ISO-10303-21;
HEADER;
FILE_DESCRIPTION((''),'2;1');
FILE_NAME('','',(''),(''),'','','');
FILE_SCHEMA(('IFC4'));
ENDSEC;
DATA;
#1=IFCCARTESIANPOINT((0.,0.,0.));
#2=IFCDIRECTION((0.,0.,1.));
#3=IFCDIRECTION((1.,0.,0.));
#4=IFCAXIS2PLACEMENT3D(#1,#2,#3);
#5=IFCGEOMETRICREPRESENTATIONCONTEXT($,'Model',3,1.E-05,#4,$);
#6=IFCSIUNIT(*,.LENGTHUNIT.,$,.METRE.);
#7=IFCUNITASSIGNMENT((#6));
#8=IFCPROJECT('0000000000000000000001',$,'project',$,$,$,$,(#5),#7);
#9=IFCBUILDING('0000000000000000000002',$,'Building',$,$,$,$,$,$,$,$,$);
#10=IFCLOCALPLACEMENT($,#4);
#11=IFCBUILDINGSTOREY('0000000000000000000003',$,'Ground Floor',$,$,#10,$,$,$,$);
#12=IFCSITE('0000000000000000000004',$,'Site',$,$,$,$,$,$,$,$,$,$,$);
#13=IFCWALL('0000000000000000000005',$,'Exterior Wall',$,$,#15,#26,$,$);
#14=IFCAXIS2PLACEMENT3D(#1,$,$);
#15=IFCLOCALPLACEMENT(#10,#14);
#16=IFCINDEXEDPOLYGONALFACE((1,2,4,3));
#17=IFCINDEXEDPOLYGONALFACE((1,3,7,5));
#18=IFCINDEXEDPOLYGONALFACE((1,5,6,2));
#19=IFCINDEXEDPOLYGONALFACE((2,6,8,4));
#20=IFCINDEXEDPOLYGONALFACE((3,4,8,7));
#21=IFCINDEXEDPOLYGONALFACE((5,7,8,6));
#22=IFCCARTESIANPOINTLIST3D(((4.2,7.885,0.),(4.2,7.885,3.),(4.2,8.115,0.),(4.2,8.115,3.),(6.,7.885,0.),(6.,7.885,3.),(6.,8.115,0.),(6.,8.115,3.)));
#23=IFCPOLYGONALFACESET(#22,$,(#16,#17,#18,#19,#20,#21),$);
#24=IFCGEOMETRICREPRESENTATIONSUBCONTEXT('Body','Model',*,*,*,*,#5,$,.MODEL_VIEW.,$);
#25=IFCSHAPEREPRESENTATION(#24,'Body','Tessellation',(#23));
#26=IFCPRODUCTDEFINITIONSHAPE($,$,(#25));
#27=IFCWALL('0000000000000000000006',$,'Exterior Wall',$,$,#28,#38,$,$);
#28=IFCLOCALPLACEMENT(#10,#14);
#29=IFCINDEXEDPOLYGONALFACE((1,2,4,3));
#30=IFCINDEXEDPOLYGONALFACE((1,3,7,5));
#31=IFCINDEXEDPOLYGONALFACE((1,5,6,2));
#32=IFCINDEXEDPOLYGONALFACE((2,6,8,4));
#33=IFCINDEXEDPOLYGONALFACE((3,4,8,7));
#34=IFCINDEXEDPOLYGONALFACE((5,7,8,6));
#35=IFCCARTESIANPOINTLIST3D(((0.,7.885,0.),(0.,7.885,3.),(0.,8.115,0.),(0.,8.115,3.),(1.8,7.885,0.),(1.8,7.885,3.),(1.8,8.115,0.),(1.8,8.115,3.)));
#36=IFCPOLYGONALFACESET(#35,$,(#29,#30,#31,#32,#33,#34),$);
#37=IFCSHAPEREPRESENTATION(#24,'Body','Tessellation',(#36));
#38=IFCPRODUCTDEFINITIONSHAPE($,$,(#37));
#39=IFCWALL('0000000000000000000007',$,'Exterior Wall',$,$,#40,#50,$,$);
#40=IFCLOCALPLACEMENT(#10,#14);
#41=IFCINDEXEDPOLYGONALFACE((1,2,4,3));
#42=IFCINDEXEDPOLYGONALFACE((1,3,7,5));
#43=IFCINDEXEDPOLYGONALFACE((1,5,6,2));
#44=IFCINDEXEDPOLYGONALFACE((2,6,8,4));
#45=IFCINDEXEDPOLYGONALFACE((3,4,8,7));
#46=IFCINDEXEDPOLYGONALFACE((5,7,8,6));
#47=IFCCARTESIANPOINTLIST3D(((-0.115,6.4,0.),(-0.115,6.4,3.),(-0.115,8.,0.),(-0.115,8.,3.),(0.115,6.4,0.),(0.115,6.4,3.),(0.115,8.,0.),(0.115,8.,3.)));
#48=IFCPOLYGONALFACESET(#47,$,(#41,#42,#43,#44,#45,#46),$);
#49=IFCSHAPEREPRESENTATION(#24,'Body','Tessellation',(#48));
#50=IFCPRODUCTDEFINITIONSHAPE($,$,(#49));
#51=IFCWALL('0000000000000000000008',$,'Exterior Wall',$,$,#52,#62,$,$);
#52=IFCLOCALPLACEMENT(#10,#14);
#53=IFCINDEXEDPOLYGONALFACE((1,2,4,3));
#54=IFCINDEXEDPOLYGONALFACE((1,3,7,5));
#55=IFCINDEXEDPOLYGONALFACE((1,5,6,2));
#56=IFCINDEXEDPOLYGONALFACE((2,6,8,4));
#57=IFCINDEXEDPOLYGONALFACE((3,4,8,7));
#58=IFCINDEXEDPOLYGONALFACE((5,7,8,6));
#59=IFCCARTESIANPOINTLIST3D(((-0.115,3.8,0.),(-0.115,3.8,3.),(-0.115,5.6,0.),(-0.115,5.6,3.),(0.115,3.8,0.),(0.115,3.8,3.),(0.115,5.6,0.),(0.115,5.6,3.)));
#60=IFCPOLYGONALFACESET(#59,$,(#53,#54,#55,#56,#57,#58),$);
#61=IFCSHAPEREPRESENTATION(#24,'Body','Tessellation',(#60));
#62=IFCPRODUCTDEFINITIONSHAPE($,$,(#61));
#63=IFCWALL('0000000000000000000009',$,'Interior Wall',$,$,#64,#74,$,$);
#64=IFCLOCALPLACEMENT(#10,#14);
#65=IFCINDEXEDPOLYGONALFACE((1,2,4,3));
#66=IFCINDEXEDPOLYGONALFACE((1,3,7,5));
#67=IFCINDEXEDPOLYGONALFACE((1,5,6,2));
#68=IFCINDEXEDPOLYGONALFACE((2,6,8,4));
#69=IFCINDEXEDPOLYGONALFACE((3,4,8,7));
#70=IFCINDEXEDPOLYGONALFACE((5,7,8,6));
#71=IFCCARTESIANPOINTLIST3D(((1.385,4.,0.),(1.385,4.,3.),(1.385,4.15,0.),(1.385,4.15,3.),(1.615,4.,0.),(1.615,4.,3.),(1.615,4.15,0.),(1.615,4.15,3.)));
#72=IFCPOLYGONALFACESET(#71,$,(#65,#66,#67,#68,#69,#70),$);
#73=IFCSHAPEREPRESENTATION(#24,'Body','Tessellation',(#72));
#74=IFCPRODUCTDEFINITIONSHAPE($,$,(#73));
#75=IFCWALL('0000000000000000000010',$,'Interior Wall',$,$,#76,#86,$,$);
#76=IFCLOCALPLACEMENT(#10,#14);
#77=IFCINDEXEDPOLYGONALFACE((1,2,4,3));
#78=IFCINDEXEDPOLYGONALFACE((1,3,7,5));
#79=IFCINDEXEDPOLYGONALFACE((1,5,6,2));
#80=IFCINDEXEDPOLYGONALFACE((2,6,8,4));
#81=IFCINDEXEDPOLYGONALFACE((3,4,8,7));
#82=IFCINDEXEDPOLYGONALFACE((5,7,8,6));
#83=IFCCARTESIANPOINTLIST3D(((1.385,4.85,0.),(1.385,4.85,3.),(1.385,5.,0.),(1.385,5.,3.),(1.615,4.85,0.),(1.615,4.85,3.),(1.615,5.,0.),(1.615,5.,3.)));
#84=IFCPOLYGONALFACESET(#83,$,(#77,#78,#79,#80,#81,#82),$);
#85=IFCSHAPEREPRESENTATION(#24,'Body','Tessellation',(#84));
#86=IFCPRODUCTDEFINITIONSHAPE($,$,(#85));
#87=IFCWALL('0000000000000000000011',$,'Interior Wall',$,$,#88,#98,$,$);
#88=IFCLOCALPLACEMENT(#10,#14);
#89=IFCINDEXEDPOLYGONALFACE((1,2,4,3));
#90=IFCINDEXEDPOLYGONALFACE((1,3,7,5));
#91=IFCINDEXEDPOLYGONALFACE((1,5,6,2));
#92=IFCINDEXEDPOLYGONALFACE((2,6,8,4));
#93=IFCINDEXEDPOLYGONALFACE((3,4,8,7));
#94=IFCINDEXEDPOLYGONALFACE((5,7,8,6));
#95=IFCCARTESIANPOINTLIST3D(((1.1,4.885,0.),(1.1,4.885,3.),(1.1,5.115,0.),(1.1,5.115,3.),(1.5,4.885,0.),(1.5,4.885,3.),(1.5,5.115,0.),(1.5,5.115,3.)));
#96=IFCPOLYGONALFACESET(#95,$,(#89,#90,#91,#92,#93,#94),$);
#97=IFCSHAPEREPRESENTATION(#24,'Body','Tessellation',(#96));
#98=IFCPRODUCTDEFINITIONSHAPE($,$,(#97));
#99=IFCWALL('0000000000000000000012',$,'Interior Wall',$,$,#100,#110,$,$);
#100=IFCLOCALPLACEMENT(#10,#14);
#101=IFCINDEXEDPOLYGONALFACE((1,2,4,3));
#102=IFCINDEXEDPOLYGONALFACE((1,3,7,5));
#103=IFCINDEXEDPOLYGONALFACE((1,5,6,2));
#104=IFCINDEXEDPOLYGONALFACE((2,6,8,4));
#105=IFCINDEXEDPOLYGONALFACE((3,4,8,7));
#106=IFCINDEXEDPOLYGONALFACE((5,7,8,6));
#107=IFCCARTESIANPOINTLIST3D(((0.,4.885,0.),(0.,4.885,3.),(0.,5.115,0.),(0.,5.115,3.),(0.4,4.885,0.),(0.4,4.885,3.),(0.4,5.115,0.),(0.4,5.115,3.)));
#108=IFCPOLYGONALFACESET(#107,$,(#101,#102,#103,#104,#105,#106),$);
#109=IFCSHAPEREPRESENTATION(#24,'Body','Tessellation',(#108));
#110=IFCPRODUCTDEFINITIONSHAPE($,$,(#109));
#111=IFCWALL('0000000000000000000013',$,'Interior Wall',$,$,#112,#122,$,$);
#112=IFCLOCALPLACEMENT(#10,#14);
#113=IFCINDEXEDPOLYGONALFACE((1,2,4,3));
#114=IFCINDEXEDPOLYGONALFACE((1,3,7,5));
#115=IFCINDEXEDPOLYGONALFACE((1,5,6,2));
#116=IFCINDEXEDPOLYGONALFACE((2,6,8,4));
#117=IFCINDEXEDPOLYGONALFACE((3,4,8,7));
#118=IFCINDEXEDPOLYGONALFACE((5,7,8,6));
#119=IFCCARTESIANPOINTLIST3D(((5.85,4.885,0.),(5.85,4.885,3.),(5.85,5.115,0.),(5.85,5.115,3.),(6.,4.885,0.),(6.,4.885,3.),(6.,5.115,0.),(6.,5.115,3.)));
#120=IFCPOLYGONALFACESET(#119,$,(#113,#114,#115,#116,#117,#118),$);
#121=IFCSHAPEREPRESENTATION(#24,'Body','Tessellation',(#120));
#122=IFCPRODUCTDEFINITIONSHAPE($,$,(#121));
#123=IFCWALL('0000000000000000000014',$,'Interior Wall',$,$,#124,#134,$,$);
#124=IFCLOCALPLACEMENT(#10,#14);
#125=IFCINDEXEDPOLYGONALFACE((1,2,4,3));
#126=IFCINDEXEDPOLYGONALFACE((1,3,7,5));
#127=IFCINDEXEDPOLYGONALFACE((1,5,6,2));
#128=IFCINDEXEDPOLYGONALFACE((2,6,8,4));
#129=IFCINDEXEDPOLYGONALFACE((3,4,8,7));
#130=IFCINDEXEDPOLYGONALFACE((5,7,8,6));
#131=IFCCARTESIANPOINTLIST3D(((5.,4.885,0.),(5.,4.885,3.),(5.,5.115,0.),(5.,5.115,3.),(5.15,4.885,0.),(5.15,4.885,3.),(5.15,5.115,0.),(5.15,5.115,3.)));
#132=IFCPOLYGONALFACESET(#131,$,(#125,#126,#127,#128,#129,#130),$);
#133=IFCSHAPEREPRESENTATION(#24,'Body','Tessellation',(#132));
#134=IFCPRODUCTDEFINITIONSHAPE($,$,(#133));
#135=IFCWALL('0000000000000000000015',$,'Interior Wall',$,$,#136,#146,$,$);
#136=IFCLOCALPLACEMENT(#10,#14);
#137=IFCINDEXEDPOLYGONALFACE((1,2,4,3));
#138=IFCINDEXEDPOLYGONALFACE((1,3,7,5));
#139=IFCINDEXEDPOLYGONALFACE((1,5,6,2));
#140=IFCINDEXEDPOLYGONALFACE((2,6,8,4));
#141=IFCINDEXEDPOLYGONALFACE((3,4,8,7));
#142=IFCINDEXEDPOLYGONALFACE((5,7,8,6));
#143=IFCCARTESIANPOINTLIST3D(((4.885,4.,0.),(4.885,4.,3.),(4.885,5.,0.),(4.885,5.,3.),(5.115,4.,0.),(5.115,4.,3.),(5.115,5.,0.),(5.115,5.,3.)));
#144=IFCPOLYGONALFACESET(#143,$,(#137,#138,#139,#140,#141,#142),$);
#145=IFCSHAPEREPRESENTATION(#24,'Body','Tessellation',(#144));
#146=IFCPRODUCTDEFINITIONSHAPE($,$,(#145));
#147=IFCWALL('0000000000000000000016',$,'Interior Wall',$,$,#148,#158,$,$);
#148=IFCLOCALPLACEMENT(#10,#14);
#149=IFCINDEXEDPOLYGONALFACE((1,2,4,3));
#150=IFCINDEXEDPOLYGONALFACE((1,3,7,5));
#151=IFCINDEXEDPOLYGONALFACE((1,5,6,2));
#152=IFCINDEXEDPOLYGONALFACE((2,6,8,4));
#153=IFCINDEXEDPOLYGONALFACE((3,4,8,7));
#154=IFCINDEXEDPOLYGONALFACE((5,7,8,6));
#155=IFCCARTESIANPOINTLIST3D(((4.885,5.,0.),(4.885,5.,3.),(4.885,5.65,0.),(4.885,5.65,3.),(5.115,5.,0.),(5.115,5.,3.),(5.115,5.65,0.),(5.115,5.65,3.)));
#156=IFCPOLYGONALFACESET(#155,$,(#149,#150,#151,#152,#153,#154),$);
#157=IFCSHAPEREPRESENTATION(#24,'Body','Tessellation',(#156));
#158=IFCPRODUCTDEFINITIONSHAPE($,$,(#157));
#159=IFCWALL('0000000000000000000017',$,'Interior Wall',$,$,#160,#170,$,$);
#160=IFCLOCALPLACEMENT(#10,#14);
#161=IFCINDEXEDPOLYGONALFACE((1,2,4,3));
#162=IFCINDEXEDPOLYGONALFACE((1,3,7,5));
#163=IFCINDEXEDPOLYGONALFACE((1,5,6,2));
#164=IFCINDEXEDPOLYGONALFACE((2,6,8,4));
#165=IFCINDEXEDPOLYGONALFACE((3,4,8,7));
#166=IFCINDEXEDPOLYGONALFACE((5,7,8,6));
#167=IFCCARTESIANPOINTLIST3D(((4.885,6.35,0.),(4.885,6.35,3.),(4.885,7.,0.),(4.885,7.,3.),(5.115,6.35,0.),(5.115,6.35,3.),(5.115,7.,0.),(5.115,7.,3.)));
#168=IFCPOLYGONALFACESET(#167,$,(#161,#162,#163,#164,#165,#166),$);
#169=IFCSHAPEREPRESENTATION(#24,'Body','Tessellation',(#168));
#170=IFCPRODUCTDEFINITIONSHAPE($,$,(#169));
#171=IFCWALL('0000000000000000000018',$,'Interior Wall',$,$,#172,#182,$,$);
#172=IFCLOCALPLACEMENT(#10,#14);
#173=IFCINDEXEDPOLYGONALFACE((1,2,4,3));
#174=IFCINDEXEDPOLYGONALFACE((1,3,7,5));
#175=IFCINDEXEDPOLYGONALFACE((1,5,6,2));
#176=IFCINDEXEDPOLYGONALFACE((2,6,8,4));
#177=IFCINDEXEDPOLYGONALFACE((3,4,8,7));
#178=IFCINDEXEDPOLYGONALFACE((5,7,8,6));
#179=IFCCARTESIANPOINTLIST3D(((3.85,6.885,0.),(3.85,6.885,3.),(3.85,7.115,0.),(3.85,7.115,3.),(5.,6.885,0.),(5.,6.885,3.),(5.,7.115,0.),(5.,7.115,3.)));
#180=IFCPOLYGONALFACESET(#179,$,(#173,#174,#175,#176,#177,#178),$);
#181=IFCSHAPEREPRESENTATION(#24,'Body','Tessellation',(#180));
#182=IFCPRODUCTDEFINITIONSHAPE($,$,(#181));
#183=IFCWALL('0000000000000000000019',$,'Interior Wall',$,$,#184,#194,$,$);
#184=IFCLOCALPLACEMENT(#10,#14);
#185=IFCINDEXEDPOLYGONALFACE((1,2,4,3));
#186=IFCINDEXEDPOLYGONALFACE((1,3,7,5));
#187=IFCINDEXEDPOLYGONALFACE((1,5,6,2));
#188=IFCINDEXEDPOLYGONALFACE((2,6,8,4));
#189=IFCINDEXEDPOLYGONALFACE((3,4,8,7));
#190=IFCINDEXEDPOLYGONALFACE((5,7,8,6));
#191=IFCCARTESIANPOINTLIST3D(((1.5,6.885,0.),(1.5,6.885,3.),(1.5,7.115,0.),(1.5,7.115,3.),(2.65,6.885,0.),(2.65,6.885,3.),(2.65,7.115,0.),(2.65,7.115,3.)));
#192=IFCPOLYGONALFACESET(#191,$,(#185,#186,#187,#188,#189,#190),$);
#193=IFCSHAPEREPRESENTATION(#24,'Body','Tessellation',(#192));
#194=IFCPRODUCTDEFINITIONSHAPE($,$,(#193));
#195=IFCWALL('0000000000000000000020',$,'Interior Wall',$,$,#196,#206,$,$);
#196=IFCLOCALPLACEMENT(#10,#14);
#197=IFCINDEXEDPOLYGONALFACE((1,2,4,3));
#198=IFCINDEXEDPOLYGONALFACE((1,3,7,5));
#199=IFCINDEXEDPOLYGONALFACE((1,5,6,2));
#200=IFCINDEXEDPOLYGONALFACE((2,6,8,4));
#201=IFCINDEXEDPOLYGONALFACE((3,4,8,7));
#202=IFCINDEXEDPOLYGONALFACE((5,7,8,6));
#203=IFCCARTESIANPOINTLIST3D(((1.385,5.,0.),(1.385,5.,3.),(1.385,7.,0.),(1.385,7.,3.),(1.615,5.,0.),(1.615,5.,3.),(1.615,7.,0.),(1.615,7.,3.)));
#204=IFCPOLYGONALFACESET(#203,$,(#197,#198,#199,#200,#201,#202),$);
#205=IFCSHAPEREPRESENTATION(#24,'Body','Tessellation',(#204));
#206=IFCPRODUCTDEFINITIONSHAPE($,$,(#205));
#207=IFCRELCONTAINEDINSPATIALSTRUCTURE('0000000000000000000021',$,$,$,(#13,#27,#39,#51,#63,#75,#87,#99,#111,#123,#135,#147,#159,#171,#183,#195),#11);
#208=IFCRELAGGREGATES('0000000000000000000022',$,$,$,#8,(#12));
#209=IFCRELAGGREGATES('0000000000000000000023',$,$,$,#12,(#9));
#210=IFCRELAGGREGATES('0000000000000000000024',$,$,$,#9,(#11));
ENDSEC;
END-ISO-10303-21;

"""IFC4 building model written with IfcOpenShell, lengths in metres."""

from ifc_helpers import new_model, si_unit, frame, origin_with_axes, place, context, subcontext, project, spatial, indexed_curve, outline, extrude, element, save


model = new_model("IFC4")

# Units and contexts
model_context = context("Model", 3, precision=1e-05, world=origin_with_axes())
body_context = subcontext(model_context, "Body", "Model", "MODEL_VIEW")
ifc_project = project(units=[si_unit("LENGTHUNIT", "METRE")], contexts=[model_context])

# Site, building, storey
site = spatial("IfcSite", under=ifc_project, Name="Site")
building = spatial("IfcBuilding", under=site, Name="Building")
storey_placement = place(None, origin_with_axes())
storey = spatial("IfcBuildingStorey", under=building, at=storey_placement, Name="Ground Floor")

# Walls
for number, where, z_axis, x_axis, name in (
    (1, (6.0, 8.0, 0.0), (0.0, 0.0, 1.0), (-1.0, 0.0, 0.0), "Exterior Wall"),
    (2, (1.8, 8.0, 0.0), (0.0, 0.0, 1.0), (-1.0, 0.0, 0.0), "Exterior Wall"),
):
    element("IfcWall", number, at=place(storey_placement, frame(where, z_axis=z_axis, x_axis=x_axis)), inside=storey, Name=name, context=body_context, shape_type="SweptSolid", body=[
        extrude(outline(indexed_curve([(0.0, 0.0), (0.0, 0.23), (1.8, 0.23), (1.8, 0.0), (0.0, 0.0)], self_intersect=False)), frame((0.0, -0.115, 0.0), z_axis=(0.0, 0.0, 1.0), x_axis=(1.0, 0.0, 0.0)), (0.0, 0.0, 1.0), 3.0),
    ])
wall_1_placement = place(storey_placement, frame((0.0, 8.0, 0.0), z_axis=(0.0, 0.0, 1.0), x_axis=(0.0, -1.0, 0.0)))
element("IfcWall", 3, at=wall_1_placement, inside=storey, Name="Exterior Wall", context=body_context, shape_type="SweptSolid", body=[
    extrude(outline(indexed_curve([(0.0, 0.0), (0.0, 0.23), (1.6, 0.23), (1.6, 0.0), (0.0, 0.0)], self_intersect=False)), frame((0.0, -0.115, 0.0), z_axis=(0.0, 0.0, 1.0), x_axis=(1.0, 0.0, 0.0)), (0.0, 0.0, 1.0), 3.0),
])
wall_2_placement = place(storey_placement, frame((0.0, 5.6, 0.0), z_axis=(0.0, 0.0, 1.0), x_axis=(0.0, -1.0, 0.0)))
element("IfcWall", 4, at=wall_2_placement, inside=storey, Name="Exterior Wall", context=body_context, shape_type="SweptSolid", body=[
    extrude(outline(indexed_curve([(0.0, 0.0), (0.0, 0.23), (1.8, 0.23), (1.8, 0.0), (0.0, 0.0)], self_intersect=False)), frame((0.0, -0.115, 0.0), z_axis=(0.0, 0.0, 1.0), x_axis=(1.0, 0.0, 0.0)), (0.0, 0.0, 1.0), 3.0),
])
for number, where, z_axis, x_axis, name in (
    (5, (1.5, 4.0, 0.0), (0.0, 0.0, 1.0), (0.0, 1.0, 0.0), "Interior Wall"),
    (6, (1.5, 4.85, 0.0), (0.0, 0.0, 1.0), (0.0, 1.0, 0.0), "Interior Wall"),
):
    element("IfcWall", number, at=place(storey_placement, frame(where, z_axis=z_axis, x_axis=x_axis)), inside=storey, Name=name, context=body_context, shape_type="SweptSolid", body=[
        extrude(outline(indexed_curve([(0.0, 0.0), (0.0, 0.23), (0.15, 0.23), (0.15, 0.0), (0.0, 0.0)], self_intersect=False)), frame((0.0, -0.115, 0.0), z_axis=(0.0, 0.0, 1.0), x_axis=(1.0, 0.0, 0.0)), (0.0, 0.0, 1.0), 3.0),
    ])
for number, where, z_axis, x_axis, name in (
    (7, (1.5, 5.0, 0.0), (0.0, 0.0, 1.0), (-1.0, 0.0, 0.0), "Interior Wall"),
    (8, (0.4, 5.0, 0.0), (0.0, 0.0, 1.0), (-1.0, 0.0, 0.0), "Interior Wall"),
):
    element("IfcWall", number, at=place(storey_placement, frame(where, z_axis=z_axis, x_axis=x_axis)), inside=storey, Name=name, context=body_context, shape_type="SweptSolid", body=[
        extrude(outline(indexed_curve([(0.0, 0.0), (0.0, 0.23), (0.4, 0.23), (0.4, 0.0), (0.0, 0.0)], self_intersect=False)), frame((0.0, -0.115, 0.0), z_axis=(0.0, 0.0, 1.0), x_axis=(1.0, 0.0, 0.0)), (0.0, 0.0, 1.0), 3.0),
    ])
for number, where, z_axis, x_axis, name in (
    (9, (6.0, 5.0, 0.0), (0.0, 0.0, 1.0), (-1.0, 0.0, 0.0), "Interior Wall"),
    (10, (5.15, 5.0, 0.0), (0.0, 0.0, 1.0), (-1.0, 0.0, 0.0), "Interior Wall"),
):
    element("IfcWall", number, at=place(storey_placement, frame(where, z_axis=z_axis, x_axis=x_axis)), inside=storey, Name=name, context=body_context, shape_type="SweptSolid", body=[
        extrude(outline(indexed_curve([(0.0, 0.0), (0.0, 0.23), (0.15, 0.23), (0.15, 0.0), (0.0, 0.0)], self_intersect=False)), frame((0.0, -0.115, 0.0), z_axis=(0.0, 0.0, 1.0), x_axis=(1.0, 0.0, 0.0)), (0.0, 0.0, 1.0), 3.0),
    ])
wall_3_placement = place(storey_placement, frame((5.0, 5.0, 0.0), z_axis=(0.0, 0.0, 1.0), x_axis=(0.0, -1.0, 0.0)))
element("IfcWall", 11, at=wall_3_placement, inside=storey, Name="Interior Wall", context=body_context, shape_type="SweptSolid", body=[
    extrude(outline(indexed_curve([(0.0, 0.0), (0.0, 0.23), (1.0, 0.23), (1.0, 0.0), (0.0, 0.0)], self_intersect=False)), frame((0.0, -0.115, 0.0), z_axis=(0.0, 0.0, 1.0), x_axis=(1.0, 0.0, 0.0)), (0.0, 0.0, 1.0), 3.0),
])
for number, where, z_axis, x_axis, name in (
    (12, (5.0, 5.0, 0.0), (0.0, 0.0, 1.0), (0.0, 1.0, 0.0), "Interior Wall"),
    (13, (5.0, 6.35, 0.0), (0.0, 0.0, 1.0), (0.0, 1.0, 0.0), "Interior Wall"),
):
    element("IfcWall", number, at=place(storey_placement, frame(where, z_axis=z_axis, x_axis=x_axis)), inside=storey, Name=name, context=body_context, shape_type="SweptSolid", body=[
        extrude(outline(indexed_curve([(0.0, 0.0), (0.0, 0.23), (0.65, 0.23), (0.65, 0.0), (0.0, 0.0)], self_intersect=False)), frame((0.0, -0.115, 0.0), z_axis=(0.0, 0.0, 1.0), x_axis=(1.0, 0.0, 0.0)), (0.0, 0.0, 1.0), 3.0),
    ])
for number, where, z_axis, x_axis, name in (
    (14, (5.0, 7.0, 0.0), (0.0, 0.0, 1.0), (-1.0, 0.0, 0.0), "Interior Wall"),
    (15, (2.65, 7.0, 0.0), (0.0, 0.0, 1.0), (-1.0, 0.0, 0.0), "Interior Wall"),
):
    element("IfcWall", number, at=place(storey_placement, frame(where, z_axis=z_axis, x_axis=x_axis)), inside=storey, Name=name, context=body_context, shape_type="SweptSolid", body=[
        extrude(outline(indexed_curve([(0.0, 0.0), (0.0, 0.23), (1.15, 0.23), (1.15, 0.0), (0.0, 0.0)], self_intersect=False)), frame((0.0, -0.115, 0.0), z_axis=(0.0, 0.0, 1.0), x_axis=(1.0, 0.0, 0.0)), (0.0, 0.0, 1.0), 3.0),
    ])
wall_4_placement = place(storey_placement, frame((1.5, 7.0, 0.0), z_axis=(0.0, 0.0, 1.0), x_axis=(0.0, -1.0, 0.0)))
element("IfcWall", 16, at=wall_4_placement, inside=storey, Name="Interior Wall", context=body_context, shape_type="SweptSolid", body=[
    extrude(outline(indexed_curve([(0.0, 0.0), (0.0, 0.23), (2.0, 0.23), (2.0, 0.0), (0.0, 0.0)], self_intersect=False)), frame((0.0, -0.115, 0.0), z_axis=(0.0, 0.0, 1.0), x_axis=(1.0, 0.0, 0.0)), (0.0, 0.0, 1.0), 3.0),
])

save(model, "model.ifc")
